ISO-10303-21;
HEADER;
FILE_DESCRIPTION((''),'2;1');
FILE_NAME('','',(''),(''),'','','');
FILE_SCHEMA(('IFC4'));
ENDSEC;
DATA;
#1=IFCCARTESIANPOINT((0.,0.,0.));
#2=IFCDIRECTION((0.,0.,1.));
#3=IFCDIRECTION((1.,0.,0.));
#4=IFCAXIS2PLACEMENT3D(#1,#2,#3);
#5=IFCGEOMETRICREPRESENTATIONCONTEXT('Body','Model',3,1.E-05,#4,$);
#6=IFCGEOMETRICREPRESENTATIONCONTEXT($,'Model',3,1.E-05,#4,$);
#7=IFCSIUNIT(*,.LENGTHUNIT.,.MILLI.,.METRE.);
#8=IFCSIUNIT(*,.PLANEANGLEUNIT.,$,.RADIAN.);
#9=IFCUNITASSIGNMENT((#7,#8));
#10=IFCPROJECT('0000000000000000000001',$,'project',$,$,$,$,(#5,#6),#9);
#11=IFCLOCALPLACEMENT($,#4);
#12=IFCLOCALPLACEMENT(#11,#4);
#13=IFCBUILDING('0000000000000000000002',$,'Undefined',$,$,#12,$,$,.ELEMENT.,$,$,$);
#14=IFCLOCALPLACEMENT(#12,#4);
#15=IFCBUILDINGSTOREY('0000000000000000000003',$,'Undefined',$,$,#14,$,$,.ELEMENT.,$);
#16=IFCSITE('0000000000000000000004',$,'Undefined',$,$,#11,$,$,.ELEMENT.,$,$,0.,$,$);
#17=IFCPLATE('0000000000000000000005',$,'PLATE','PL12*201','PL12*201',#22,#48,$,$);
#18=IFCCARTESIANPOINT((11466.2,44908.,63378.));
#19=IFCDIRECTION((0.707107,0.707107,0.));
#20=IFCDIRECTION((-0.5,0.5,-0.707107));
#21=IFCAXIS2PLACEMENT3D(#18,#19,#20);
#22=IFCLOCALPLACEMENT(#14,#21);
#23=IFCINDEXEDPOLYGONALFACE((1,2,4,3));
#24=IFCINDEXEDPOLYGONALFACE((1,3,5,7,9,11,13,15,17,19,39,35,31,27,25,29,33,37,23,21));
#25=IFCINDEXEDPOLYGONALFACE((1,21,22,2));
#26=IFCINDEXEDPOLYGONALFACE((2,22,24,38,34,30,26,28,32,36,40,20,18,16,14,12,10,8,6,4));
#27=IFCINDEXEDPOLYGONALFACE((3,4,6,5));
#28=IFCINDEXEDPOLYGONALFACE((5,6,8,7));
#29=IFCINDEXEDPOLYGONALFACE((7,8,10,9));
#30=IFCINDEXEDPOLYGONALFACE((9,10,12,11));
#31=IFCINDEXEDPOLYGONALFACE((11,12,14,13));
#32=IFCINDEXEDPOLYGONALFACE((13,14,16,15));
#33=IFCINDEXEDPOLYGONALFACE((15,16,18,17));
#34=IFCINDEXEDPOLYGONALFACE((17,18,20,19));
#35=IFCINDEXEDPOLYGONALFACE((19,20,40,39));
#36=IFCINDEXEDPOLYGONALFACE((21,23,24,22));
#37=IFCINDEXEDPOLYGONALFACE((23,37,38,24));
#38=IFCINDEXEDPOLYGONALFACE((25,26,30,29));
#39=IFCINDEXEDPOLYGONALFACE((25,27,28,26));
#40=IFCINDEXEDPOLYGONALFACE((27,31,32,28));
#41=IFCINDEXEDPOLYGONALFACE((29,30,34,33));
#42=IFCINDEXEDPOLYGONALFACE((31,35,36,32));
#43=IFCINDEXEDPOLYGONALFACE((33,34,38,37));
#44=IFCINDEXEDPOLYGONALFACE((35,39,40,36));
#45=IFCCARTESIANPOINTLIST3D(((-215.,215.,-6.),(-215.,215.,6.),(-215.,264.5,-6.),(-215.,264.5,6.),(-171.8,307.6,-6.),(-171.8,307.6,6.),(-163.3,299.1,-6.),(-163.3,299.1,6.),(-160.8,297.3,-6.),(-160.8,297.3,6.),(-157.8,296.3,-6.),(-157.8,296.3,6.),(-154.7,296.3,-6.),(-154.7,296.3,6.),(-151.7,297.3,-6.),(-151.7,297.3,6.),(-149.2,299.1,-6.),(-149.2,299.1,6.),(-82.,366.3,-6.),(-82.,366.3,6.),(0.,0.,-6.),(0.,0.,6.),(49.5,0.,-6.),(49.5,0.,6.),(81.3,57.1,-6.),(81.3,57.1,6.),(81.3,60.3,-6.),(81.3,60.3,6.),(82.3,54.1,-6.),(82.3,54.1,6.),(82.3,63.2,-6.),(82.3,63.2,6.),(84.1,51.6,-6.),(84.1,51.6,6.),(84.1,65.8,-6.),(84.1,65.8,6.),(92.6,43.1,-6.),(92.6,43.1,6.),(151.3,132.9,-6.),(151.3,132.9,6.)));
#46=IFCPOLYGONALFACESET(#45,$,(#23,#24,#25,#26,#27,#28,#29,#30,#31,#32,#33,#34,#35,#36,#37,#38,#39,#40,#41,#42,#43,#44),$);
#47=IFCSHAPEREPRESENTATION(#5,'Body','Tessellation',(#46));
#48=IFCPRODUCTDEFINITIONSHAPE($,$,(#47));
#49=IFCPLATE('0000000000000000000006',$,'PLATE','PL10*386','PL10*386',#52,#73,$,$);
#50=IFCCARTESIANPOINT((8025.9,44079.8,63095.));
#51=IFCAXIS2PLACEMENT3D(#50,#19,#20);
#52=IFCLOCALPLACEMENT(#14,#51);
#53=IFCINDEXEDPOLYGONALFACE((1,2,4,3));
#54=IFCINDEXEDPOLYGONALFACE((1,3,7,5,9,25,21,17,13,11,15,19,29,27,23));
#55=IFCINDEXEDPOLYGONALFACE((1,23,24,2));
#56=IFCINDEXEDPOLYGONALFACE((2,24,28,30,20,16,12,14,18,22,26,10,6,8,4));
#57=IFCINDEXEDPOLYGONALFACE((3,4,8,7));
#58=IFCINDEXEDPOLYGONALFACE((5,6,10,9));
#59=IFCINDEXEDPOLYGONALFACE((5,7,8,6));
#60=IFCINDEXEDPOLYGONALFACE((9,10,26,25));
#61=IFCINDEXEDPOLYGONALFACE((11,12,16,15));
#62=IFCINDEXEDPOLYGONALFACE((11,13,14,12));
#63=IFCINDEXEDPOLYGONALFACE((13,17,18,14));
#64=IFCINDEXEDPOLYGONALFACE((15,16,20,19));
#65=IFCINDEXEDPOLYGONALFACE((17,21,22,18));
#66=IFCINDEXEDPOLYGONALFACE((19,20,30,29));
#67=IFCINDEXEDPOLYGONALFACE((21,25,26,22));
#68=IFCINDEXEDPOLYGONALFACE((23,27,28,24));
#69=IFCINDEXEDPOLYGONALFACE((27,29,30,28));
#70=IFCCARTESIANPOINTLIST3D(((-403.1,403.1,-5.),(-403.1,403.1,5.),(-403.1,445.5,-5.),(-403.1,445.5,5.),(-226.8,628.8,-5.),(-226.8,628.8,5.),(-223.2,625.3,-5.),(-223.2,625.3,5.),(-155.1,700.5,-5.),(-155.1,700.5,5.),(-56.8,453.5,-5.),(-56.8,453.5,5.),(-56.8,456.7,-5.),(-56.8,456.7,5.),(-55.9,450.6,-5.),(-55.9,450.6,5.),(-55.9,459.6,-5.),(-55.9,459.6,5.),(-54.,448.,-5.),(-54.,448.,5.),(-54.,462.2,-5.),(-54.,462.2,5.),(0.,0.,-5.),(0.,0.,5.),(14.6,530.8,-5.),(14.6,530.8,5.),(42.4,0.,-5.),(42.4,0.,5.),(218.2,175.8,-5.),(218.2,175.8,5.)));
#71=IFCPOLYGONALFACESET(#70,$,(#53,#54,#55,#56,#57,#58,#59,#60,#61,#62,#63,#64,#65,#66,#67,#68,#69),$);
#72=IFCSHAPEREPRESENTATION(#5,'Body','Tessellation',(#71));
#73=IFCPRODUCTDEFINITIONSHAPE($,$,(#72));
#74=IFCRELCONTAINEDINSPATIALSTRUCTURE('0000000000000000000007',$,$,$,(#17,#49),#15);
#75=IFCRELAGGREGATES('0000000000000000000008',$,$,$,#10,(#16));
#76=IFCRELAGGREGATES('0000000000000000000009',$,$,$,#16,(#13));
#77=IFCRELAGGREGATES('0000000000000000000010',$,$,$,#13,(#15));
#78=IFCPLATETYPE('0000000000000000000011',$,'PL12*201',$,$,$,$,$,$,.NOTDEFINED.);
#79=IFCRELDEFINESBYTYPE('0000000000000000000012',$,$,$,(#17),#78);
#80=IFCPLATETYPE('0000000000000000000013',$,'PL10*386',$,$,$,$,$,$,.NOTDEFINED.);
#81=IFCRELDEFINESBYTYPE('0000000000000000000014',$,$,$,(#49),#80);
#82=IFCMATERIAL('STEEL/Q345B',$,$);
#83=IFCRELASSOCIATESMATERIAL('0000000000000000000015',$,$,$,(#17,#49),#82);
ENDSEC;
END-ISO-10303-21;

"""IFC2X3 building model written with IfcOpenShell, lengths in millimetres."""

from ifc_helpers import new_model, si_unit, frame, origin_with_axes, place, context, project, spatial, polyline, outline, extrude, material, type_object, element, save


model = new_model("IFC2X3")

# Units and contexts
model_context_1 = context("Model", 3, precision=1e-05, world=origin_with_axes(), identifier="Body")
model_context_2 = context("Model", 3, precision=1e-05, world=origin_with_axes())
ifc_project = project(units=[si_unit("LENGTHUNIT", "METRE", prefix="MILLI"), si_unit("PLANEANGLEUNIT", "RADIAN")], contexts=[model_context_1, model_context_2])

# Site, building, storey
site_placement = place(None, origin_with_axes())
site = spatial("IfcSite", under=ifc_project, at=site_placement, Name="Undefined", CompositionType="ELEMENT", RefElevation=0.0)
building_placement = place(site_placement, origin_with_axes())
building = spatial("IfcBuilding", under=site, at=building_placement, Name="Undefined", CompositionType="ELEMENT")
storey_placement = place(building_placement, origin_with_axes())
storey = spatial("IfcBuildingStorey", under=building, at=storey_placement, Name="Undefined", CompositionType="ELEMENT")

# Shared definitions
ifc_material_1 = material(Name="STEEL/Q345B")

# Plates
plate_type_1 = type_object("IfcPlateType", Name="PL12*201", PredefinedType="NOTDEFINED")
plate_1_placement = place(storey_placement, frame((11466.2, 44908.0, 63378.0), z_axis=(0.707107, 0.707107, 0.0), x_axis=(-0.5, 0.5, -0.707107)))
element("IfcPlate", 1, at=plate_1_placement, inside=storey, type_object=plate_type_1, material=ifc_material_1, Name="PLATE", Description="PL12*201", ObjectType="PL12*201", context=model_context_1, shape_type="SweptSolid", body=[
    extrude(outline(polyline([(0.0, 0.0), (49.5, 0.0), (92.6, 43.1), (84.1, 51.6), (82.3, 54.1), (81.3, 57.1), (81.3, 60.3), (82.3, 63.2), (84.1, 65.8), (151.3, 132.9), (-82.0, 366.3), (-149.2, 299.1), (-151.7, 297.3), (-154.7, 296.3), (-157.8, 296.3), (-160.8, 297.3), (-163.3, 299.1), (-171.8, 307.6), (-215.0, 264.5), (-215.0, 215.0), (0.0, 0.0)])), frame((0.0, 0.0, -6.0), z_axis=(0.0, 0.0, 1.0), x_axis=(1.0, 0.0, 0.0)), (0.0, 0.0, 1.0), 12.0),
])
plate_type_2 = type_object("IfcPlateType", Name="PL10*386", PredefinedType="NOTDEFINED")
plate_2_placement = place(storey_placement, frame((8025.9, 44079.8, 63095.0), z_axis=(0.707107, 0.707107, 0.0), x_axis=(-0.5, 0.5, -0.707107)))
element("IfcPlate", 2, at=plate_2_placement, inside=storey, type_object=plate_type_2, material=ifc_material_1, Name="PLATE", Description="PL10*386", ObjectType="PL10*386", context=model_context_1, shape_type="SweptSolid", body=[
    extrude(outline(polyline([(0.0, 0.0), (42.4, 0.0), (218.2, 175.8), (-54.0, 448.0), (-55.9, 450.6), (-56.8, 453.5), (-56.8, 456.7), (-55.9, 459.6), (-54.0, 462.2), (14.6, 530.8), (-155.1, 700.5), (-226.8, 628.8), (-223.2, 625.3), (-403.1, 445.5), (-403.1, 403.1), (0.0, 0.0)])), frame((0.0, 0.0, -5.0), z_axis=(0.0, 0.0, 1.0), x_axis=(1.0, 0.0, 0.0)), (0.0, 0.0, 1.0), 10.0),
])

save(model, "model.ifc")
